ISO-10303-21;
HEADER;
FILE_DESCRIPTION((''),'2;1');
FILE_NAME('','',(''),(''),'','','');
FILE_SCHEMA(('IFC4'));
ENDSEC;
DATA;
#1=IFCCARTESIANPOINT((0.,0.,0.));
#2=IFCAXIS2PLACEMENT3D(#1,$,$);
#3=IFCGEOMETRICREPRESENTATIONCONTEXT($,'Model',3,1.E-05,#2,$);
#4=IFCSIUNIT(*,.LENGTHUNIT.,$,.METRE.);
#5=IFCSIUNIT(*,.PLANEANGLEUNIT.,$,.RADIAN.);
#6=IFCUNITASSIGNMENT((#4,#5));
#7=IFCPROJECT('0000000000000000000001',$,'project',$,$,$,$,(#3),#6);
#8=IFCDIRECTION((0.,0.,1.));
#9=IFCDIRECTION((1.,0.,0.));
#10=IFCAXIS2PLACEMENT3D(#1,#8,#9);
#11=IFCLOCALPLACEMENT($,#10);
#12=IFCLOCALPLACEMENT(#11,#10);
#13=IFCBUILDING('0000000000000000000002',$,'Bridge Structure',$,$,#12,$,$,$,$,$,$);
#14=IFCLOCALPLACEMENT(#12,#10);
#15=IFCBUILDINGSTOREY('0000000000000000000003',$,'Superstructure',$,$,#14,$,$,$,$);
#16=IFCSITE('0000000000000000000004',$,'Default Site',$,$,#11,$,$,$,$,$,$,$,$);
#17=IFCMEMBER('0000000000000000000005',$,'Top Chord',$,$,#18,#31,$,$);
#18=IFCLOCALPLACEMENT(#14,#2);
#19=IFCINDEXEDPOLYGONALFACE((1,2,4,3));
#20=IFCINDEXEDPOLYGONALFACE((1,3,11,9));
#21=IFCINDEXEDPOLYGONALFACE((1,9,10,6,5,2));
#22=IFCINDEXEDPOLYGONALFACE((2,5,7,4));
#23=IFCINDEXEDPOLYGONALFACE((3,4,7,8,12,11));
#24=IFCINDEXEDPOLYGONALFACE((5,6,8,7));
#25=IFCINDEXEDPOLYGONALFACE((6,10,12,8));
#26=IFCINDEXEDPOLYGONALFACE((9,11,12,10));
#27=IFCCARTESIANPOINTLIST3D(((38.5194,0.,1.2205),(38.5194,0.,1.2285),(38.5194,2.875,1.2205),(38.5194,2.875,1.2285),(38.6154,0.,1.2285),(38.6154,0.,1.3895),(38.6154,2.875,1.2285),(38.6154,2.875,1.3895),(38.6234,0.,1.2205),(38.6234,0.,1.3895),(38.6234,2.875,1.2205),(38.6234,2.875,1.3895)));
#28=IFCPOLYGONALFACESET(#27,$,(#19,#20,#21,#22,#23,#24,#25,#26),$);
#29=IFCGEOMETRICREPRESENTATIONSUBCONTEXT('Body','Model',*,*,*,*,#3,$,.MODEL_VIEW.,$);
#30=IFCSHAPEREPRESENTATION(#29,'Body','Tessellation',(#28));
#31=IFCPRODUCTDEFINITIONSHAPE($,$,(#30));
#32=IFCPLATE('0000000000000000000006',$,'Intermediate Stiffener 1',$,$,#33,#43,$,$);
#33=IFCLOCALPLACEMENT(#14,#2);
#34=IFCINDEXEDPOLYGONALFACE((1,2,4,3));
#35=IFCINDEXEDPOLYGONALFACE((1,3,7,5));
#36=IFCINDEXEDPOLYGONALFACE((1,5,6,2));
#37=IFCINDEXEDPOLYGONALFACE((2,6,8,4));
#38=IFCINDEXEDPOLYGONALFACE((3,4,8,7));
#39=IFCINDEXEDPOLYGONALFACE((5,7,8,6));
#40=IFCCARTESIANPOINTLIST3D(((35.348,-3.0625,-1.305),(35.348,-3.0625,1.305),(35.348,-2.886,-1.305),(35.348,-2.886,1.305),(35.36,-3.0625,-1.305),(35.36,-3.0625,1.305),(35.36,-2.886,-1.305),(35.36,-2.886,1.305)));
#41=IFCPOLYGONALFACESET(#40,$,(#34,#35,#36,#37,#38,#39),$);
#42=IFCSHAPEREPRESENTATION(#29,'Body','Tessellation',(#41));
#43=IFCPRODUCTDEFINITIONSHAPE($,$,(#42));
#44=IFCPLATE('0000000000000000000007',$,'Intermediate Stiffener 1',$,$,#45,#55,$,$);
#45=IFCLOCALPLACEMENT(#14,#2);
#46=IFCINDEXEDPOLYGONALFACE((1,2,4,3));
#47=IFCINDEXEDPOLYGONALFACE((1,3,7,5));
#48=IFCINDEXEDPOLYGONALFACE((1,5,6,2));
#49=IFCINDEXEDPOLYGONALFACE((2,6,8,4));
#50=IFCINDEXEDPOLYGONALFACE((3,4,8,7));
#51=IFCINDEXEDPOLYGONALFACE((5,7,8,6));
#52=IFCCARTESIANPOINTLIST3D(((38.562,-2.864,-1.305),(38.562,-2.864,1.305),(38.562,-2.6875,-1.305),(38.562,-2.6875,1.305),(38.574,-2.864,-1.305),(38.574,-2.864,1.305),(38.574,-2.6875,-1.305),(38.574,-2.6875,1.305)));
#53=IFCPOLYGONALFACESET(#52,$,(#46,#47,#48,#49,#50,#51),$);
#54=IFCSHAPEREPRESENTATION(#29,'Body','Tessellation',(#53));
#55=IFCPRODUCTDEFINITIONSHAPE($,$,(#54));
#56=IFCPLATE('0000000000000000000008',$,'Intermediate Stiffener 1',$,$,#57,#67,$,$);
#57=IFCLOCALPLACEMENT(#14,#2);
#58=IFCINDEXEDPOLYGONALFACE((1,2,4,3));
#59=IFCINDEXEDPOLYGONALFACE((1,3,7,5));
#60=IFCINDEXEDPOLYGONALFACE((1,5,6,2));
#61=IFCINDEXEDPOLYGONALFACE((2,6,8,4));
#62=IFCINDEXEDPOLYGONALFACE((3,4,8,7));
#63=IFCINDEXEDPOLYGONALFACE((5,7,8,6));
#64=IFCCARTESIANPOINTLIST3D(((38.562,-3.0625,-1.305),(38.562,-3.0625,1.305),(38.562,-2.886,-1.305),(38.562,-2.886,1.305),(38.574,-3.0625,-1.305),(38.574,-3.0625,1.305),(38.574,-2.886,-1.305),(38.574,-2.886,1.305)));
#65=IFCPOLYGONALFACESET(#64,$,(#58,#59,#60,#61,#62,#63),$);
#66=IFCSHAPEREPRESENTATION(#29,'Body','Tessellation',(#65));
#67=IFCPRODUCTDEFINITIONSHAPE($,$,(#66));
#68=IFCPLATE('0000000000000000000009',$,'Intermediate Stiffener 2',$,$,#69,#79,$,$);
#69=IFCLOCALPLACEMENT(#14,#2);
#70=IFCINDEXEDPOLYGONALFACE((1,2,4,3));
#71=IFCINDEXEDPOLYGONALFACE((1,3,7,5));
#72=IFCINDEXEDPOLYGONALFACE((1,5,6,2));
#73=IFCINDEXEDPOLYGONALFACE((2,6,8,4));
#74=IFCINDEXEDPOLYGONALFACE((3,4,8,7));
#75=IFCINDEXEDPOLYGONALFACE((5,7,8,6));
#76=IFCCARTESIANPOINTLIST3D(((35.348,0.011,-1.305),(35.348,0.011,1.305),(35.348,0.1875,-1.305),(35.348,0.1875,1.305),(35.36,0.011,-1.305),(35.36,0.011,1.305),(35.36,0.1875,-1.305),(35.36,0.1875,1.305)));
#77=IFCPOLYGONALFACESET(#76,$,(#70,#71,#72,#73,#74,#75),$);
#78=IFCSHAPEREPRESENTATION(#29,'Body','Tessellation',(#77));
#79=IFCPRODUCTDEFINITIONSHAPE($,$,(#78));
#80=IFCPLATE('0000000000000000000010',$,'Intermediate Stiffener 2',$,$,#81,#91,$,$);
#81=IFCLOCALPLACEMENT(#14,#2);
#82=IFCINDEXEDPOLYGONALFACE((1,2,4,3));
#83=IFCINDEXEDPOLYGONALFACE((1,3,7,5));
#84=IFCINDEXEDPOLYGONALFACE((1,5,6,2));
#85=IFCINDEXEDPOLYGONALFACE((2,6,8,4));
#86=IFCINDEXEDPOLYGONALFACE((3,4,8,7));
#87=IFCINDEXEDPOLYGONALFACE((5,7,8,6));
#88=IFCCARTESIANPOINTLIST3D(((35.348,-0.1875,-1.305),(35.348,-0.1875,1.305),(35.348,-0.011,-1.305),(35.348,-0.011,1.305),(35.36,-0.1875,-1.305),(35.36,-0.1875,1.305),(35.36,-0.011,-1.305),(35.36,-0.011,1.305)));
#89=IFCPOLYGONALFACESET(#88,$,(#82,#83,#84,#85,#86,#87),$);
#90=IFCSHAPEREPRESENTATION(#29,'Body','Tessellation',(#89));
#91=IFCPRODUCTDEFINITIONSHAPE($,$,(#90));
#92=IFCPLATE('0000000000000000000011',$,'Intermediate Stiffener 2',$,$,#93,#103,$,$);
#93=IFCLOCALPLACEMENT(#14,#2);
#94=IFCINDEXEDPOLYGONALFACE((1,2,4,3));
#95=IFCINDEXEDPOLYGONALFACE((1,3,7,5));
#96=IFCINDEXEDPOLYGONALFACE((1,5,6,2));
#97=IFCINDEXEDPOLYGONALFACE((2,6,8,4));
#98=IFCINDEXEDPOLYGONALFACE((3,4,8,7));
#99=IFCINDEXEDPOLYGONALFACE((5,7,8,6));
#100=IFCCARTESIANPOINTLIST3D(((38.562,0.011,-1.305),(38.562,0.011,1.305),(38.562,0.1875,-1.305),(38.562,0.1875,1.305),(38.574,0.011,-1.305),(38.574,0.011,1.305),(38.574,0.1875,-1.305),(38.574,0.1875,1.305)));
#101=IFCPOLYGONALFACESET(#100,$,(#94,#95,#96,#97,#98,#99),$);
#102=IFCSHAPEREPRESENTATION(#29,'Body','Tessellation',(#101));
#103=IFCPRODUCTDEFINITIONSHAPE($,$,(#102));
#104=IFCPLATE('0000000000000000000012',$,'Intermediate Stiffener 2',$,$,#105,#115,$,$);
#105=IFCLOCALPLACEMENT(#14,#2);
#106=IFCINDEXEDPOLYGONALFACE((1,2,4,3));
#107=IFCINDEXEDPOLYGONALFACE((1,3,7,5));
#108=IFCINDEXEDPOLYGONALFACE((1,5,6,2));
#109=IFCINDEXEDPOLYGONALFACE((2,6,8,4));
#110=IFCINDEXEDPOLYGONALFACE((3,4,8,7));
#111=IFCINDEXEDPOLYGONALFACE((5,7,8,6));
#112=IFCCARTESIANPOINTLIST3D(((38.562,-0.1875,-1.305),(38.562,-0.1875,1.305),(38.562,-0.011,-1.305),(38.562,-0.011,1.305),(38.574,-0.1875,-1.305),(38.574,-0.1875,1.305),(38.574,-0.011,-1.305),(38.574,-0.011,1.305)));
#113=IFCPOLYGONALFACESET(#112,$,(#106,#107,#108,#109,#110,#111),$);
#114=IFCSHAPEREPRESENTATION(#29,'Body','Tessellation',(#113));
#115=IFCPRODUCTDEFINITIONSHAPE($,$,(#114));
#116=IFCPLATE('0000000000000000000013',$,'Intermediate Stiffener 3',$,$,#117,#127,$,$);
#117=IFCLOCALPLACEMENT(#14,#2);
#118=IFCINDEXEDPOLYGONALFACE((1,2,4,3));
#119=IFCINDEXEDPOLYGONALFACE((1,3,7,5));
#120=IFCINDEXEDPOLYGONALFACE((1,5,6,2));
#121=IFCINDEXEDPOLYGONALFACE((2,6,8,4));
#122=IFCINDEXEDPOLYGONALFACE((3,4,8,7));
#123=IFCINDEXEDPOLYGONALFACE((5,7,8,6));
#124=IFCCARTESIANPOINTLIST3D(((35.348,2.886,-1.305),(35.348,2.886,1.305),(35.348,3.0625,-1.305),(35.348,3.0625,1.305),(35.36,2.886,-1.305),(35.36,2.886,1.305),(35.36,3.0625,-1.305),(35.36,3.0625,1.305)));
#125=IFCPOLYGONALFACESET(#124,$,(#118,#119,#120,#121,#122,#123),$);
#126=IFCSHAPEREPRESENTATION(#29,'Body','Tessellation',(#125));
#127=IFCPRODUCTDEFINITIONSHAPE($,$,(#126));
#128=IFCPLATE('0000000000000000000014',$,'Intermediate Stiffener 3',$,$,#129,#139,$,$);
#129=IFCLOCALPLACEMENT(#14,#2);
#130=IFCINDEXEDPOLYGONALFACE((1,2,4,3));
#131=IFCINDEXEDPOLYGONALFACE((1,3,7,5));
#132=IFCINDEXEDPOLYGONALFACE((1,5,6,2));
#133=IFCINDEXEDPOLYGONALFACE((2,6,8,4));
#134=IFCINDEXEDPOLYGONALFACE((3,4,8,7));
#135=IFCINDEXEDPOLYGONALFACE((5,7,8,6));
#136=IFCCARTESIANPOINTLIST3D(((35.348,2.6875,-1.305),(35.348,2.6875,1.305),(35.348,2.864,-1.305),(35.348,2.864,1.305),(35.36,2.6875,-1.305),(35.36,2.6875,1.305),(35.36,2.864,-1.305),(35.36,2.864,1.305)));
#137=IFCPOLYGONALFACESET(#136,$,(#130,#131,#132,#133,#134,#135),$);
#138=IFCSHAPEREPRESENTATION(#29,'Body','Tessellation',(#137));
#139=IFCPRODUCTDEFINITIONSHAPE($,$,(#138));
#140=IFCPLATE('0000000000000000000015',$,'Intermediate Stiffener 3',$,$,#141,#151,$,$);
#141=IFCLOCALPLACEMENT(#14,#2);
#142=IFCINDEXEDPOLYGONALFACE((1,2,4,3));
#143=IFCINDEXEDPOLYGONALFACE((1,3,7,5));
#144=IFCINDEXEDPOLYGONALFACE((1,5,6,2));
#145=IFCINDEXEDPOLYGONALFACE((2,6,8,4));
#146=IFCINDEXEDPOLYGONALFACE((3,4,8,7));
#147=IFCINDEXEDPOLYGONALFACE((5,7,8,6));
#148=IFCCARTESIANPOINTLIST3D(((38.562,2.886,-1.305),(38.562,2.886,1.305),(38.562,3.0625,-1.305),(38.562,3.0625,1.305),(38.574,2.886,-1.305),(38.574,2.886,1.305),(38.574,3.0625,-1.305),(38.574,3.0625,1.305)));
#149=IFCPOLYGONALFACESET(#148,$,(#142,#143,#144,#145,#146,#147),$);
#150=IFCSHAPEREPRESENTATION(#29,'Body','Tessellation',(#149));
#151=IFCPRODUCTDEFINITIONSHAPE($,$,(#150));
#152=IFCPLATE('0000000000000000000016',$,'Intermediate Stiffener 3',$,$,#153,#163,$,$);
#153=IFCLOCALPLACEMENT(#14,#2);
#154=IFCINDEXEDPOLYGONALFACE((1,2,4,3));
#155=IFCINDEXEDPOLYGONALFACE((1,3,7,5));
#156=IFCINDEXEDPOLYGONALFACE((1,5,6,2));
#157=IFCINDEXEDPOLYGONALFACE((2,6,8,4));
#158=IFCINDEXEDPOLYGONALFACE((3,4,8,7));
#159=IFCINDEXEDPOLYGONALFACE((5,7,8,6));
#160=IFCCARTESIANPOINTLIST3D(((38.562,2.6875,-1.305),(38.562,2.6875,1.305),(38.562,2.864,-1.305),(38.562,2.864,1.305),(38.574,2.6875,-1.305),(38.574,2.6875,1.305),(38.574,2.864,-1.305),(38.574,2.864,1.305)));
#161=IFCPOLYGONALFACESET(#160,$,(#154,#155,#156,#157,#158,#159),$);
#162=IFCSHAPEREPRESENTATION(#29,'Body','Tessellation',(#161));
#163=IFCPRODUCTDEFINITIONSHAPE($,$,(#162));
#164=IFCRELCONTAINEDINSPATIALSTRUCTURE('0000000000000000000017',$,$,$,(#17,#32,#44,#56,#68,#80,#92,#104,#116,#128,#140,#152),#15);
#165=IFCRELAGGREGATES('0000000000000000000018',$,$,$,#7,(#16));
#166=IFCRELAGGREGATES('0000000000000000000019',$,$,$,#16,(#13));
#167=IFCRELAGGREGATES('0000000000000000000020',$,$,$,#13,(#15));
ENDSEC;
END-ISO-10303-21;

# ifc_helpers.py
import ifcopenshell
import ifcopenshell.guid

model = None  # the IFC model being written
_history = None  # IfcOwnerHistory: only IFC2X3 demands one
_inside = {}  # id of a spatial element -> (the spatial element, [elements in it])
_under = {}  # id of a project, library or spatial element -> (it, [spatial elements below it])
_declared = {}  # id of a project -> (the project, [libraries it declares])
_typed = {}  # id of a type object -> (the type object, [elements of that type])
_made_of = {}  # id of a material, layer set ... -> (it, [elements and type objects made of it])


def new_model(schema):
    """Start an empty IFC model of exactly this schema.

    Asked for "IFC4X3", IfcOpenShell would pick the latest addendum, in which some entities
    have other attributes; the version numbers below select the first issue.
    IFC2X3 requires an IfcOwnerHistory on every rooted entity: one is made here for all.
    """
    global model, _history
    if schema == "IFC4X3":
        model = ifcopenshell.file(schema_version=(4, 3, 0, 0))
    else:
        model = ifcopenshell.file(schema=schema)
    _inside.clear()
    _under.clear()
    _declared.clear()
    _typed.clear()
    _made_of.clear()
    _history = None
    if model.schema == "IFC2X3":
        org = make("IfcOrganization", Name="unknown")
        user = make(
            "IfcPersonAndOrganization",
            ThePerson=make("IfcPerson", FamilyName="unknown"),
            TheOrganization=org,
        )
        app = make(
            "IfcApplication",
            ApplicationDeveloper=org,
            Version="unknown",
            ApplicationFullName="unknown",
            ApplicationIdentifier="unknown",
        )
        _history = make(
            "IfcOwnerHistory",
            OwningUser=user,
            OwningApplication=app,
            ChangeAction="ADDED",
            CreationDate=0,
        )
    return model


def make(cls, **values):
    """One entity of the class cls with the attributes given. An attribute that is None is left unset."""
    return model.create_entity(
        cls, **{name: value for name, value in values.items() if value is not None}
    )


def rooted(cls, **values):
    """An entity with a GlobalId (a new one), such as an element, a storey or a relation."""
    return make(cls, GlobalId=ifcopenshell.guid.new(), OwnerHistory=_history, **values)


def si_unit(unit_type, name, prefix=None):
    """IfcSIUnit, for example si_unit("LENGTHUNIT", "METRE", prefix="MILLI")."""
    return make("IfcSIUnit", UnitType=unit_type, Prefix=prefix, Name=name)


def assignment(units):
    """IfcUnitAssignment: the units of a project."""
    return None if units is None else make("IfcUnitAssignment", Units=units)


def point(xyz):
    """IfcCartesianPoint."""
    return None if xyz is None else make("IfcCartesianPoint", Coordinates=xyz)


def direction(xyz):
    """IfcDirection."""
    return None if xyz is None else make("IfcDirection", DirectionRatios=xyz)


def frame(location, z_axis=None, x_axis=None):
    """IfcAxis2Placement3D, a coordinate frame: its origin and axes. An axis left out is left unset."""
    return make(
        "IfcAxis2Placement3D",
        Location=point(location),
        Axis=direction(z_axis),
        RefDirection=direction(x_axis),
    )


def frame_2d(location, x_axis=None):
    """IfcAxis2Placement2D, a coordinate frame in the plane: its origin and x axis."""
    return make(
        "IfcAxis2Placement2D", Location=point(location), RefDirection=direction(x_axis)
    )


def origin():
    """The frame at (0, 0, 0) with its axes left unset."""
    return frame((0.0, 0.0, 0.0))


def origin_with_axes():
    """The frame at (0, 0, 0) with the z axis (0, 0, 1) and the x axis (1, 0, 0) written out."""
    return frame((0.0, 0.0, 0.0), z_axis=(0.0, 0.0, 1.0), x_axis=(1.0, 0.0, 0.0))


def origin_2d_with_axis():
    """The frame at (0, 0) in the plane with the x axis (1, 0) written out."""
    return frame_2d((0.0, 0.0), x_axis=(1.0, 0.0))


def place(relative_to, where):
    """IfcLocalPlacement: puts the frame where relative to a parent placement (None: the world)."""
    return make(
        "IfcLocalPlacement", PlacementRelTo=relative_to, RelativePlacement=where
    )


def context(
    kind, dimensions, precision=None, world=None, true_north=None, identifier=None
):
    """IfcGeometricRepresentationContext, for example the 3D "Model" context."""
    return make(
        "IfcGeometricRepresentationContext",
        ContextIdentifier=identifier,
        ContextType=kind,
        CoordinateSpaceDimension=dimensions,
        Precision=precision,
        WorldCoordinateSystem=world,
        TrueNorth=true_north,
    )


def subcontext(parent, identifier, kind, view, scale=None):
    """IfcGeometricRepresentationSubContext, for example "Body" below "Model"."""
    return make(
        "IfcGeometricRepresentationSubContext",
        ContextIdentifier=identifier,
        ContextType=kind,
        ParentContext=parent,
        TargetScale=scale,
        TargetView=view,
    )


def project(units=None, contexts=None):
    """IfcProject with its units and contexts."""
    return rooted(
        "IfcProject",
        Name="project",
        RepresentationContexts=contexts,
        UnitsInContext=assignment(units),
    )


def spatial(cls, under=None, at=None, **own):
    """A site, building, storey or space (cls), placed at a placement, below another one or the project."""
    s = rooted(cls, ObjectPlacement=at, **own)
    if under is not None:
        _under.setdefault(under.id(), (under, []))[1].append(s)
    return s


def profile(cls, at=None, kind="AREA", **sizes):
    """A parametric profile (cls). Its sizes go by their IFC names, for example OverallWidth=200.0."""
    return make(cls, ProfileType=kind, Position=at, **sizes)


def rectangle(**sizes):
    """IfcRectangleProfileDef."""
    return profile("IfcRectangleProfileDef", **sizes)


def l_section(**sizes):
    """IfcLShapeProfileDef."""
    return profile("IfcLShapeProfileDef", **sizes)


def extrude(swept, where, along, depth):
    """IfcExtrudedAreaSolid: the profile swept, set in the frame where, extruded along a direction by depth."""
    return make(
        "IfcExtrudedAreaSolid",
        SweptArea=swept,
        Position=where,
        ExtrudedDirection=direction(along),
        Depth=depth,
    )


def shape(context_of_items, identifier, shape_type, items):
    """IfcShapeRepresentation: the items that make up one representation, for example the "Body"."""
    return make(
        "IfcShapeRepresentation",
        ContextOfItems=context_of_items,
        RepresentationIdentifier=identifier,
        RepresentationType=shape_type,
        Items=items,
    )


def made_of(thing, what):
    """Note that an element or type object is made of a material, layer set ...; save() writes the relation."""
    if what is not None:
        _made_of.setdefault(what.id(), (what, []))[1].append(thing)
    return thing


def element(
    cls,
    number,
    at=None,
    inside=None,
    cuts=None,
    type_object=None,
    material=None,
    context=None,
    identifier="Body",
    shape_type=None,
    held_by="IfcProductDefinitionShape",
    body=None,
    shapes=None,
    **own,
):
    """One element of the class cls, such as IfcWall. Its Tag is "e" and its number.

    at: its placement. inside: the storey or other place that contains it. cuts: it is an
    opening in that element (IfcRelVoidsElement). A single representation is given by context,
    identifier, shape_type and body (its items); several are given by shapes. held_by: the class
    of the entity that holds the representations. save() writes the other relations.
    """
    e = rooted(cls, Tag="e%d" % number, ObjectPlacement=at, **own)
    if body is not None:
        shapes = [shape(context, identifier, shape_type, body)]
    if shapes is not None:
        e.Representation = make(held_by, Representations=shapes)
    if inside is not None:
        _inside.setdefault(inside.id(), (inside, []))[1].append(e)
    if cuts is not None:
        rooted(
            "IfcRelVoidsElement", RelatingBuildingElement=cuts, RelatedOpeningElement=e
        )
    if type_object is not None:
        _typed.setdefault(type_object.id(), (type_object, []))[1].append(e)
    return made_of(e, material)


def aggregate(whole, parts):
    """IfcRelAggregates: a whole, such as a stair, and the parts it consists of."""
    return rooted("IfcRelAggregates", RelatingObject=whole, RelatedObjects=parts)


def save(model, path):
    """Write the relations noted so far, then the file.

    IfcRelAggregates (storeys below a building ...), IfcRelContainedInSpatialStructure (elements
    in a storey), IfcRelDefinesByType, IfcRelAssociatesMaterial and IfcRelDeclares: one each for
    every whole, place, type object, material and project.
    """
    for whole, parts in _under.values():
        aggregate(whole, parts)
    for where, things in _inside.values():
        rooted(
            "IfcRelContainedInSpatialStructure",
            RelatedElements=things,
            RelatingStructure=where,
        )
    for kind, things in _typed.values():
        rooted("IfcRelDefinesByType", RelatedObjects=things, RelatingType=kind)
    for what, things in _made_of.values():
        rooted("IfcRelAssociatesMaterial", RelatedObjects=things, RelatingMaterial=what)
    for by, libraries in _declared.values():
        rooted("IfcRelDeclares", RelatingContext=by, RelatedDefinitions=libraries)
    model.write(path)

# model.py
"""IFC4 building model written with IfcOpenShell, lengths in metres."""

from ifc_helpers import new_model, si_unit, frame, origin, origin_with_axes, origin_2d_with_axis, place, context, subcontext, project, spatial, rectangle, l_section, extrude, element, save


model = new_model("IFC4")

# Units and contexts
model_context = context("Model", 3, precision=1e-05, world=origin())
body_context = subcontext(model_context, "Body", "Model", "MODEL_VIEW")
ifc_project = project(units=[si_unit("LENGTHUNIT", "METRE"), si_unit("PLANEANGLEUNIT", "RADIAN")], contexts=[model_context])

# Site, building, storey
site_placement = place(None, origin_with_axes())
site = spatial("IfcSite", under=ifc_project, at=site_placement, Name="Default Site")
building_placement = place(site_placement, origin_with_axes())
building = spatial("IfcBuilding", under=site, at=building_placement, Name="Bridge Structure")
storey_placement = place(building_placement, origin_with_axes())
storey = spatial("IfcBuildingStorey", under=building, at=storey_placement, Name="Superstructure")

# Member
for number, where, z_axis, x_axis, name in (
    (1, (38.5714, 0.0, 1.305), (0.0, 1.0, 0.0), (-1.0, 0.0, 0.0), "Top Chord"),
):
    element("IfcMember", number, at=place(storey_placement, frame(where, z_axis=z_axis, x_axis=x_axis)), inside=storey, Name=name, context=body_context, shape_type="SweptSolid", body=[
        extrude(l_section(Depth=0.169, Width=0.104, Thickness=0.008, at=origin_2d_with_axis()), origin_with_axes(), (0.0, 0.0, 1.0), 2.875),
    ])

# Plates
for number, where, z_axis, x_axis, name in (
    (2, (35.354, -2.9743, -1.305), (0.0, 0.0, 1.0), (1.0, 0.0, 0.0), "Intermediate Stiffener 1"),
    (3, (38.568, -2.7757, -1.305), (0.0, 0.0, 1.0), (1.0, 0.0, 0.0), "Intermediate Stiffener 1"),
    (4, (38.568, -2.9743, -1.305), (0.0, 0.0, 1.0), (1.0, 0.0, 0.0), "Intermediate Stiffener 1"),
    (5, (35.354, 0.0993, -1.305), (0.0, 0.0, 1.0), (1.0, 0.0, 0.0), "Intermediate Stiffener 2"),
    (6, (35.354, -0.0993, -1.305), (0.0, 0.0, 1.0), (1.0, 0.0, 0.0), "Intermediate Stiffener 2"),
    (7, (38.568, 0.0993, -1.305), (0.0, 0.0, 1.0), (1.0, 0.0, 0.0), "Intermediate Stiffener 2"),
    (8, (38.568, -0.0993, -1.305), (0.0, 0.0, 1.0), (1.0, 0.0, 0.0), "Intermediate Stiffener 2"),
    (9, (35.354, 2.9743, -1.305), (0.0, 0.0, 1.0), (1.0, 0.0, 0.0), "Intermediate Stiffener 3"),
    (10, (35.354, 2.7757, -1.305), (0.0, 0.0, 1.0), (1.0, 0.0, 0.0), "Intermediate Stiffener 3"),
    (11, (38.568, 2.9743, -1.305), (0.0, 0.0, 1.0), (1.0, 0.0, 0.0), "Intermediate Stiffener 3"),
    (12, (38.568, 2.7757, -1.305), (0.0, 0.0, 1.0), (1.0, 0.0, 0.0), "Intermediate Stiffener 3"),
):
    element("IfcPlate", number, at=place(storey_placement, frame(where, z_axis=z_axis, x_axis=x_axis)), inside=storey, Name=name, context=body_context, shape_type="SweptSolid", body=[
        extrude(rectangle(XDim=0.012, YDim=0.1765, at=origin_2d_with_axis()), origin_with_axes(), (0.0, 0.0, 1.0), 2.61),
    ])

save(model, "model.ifc")
